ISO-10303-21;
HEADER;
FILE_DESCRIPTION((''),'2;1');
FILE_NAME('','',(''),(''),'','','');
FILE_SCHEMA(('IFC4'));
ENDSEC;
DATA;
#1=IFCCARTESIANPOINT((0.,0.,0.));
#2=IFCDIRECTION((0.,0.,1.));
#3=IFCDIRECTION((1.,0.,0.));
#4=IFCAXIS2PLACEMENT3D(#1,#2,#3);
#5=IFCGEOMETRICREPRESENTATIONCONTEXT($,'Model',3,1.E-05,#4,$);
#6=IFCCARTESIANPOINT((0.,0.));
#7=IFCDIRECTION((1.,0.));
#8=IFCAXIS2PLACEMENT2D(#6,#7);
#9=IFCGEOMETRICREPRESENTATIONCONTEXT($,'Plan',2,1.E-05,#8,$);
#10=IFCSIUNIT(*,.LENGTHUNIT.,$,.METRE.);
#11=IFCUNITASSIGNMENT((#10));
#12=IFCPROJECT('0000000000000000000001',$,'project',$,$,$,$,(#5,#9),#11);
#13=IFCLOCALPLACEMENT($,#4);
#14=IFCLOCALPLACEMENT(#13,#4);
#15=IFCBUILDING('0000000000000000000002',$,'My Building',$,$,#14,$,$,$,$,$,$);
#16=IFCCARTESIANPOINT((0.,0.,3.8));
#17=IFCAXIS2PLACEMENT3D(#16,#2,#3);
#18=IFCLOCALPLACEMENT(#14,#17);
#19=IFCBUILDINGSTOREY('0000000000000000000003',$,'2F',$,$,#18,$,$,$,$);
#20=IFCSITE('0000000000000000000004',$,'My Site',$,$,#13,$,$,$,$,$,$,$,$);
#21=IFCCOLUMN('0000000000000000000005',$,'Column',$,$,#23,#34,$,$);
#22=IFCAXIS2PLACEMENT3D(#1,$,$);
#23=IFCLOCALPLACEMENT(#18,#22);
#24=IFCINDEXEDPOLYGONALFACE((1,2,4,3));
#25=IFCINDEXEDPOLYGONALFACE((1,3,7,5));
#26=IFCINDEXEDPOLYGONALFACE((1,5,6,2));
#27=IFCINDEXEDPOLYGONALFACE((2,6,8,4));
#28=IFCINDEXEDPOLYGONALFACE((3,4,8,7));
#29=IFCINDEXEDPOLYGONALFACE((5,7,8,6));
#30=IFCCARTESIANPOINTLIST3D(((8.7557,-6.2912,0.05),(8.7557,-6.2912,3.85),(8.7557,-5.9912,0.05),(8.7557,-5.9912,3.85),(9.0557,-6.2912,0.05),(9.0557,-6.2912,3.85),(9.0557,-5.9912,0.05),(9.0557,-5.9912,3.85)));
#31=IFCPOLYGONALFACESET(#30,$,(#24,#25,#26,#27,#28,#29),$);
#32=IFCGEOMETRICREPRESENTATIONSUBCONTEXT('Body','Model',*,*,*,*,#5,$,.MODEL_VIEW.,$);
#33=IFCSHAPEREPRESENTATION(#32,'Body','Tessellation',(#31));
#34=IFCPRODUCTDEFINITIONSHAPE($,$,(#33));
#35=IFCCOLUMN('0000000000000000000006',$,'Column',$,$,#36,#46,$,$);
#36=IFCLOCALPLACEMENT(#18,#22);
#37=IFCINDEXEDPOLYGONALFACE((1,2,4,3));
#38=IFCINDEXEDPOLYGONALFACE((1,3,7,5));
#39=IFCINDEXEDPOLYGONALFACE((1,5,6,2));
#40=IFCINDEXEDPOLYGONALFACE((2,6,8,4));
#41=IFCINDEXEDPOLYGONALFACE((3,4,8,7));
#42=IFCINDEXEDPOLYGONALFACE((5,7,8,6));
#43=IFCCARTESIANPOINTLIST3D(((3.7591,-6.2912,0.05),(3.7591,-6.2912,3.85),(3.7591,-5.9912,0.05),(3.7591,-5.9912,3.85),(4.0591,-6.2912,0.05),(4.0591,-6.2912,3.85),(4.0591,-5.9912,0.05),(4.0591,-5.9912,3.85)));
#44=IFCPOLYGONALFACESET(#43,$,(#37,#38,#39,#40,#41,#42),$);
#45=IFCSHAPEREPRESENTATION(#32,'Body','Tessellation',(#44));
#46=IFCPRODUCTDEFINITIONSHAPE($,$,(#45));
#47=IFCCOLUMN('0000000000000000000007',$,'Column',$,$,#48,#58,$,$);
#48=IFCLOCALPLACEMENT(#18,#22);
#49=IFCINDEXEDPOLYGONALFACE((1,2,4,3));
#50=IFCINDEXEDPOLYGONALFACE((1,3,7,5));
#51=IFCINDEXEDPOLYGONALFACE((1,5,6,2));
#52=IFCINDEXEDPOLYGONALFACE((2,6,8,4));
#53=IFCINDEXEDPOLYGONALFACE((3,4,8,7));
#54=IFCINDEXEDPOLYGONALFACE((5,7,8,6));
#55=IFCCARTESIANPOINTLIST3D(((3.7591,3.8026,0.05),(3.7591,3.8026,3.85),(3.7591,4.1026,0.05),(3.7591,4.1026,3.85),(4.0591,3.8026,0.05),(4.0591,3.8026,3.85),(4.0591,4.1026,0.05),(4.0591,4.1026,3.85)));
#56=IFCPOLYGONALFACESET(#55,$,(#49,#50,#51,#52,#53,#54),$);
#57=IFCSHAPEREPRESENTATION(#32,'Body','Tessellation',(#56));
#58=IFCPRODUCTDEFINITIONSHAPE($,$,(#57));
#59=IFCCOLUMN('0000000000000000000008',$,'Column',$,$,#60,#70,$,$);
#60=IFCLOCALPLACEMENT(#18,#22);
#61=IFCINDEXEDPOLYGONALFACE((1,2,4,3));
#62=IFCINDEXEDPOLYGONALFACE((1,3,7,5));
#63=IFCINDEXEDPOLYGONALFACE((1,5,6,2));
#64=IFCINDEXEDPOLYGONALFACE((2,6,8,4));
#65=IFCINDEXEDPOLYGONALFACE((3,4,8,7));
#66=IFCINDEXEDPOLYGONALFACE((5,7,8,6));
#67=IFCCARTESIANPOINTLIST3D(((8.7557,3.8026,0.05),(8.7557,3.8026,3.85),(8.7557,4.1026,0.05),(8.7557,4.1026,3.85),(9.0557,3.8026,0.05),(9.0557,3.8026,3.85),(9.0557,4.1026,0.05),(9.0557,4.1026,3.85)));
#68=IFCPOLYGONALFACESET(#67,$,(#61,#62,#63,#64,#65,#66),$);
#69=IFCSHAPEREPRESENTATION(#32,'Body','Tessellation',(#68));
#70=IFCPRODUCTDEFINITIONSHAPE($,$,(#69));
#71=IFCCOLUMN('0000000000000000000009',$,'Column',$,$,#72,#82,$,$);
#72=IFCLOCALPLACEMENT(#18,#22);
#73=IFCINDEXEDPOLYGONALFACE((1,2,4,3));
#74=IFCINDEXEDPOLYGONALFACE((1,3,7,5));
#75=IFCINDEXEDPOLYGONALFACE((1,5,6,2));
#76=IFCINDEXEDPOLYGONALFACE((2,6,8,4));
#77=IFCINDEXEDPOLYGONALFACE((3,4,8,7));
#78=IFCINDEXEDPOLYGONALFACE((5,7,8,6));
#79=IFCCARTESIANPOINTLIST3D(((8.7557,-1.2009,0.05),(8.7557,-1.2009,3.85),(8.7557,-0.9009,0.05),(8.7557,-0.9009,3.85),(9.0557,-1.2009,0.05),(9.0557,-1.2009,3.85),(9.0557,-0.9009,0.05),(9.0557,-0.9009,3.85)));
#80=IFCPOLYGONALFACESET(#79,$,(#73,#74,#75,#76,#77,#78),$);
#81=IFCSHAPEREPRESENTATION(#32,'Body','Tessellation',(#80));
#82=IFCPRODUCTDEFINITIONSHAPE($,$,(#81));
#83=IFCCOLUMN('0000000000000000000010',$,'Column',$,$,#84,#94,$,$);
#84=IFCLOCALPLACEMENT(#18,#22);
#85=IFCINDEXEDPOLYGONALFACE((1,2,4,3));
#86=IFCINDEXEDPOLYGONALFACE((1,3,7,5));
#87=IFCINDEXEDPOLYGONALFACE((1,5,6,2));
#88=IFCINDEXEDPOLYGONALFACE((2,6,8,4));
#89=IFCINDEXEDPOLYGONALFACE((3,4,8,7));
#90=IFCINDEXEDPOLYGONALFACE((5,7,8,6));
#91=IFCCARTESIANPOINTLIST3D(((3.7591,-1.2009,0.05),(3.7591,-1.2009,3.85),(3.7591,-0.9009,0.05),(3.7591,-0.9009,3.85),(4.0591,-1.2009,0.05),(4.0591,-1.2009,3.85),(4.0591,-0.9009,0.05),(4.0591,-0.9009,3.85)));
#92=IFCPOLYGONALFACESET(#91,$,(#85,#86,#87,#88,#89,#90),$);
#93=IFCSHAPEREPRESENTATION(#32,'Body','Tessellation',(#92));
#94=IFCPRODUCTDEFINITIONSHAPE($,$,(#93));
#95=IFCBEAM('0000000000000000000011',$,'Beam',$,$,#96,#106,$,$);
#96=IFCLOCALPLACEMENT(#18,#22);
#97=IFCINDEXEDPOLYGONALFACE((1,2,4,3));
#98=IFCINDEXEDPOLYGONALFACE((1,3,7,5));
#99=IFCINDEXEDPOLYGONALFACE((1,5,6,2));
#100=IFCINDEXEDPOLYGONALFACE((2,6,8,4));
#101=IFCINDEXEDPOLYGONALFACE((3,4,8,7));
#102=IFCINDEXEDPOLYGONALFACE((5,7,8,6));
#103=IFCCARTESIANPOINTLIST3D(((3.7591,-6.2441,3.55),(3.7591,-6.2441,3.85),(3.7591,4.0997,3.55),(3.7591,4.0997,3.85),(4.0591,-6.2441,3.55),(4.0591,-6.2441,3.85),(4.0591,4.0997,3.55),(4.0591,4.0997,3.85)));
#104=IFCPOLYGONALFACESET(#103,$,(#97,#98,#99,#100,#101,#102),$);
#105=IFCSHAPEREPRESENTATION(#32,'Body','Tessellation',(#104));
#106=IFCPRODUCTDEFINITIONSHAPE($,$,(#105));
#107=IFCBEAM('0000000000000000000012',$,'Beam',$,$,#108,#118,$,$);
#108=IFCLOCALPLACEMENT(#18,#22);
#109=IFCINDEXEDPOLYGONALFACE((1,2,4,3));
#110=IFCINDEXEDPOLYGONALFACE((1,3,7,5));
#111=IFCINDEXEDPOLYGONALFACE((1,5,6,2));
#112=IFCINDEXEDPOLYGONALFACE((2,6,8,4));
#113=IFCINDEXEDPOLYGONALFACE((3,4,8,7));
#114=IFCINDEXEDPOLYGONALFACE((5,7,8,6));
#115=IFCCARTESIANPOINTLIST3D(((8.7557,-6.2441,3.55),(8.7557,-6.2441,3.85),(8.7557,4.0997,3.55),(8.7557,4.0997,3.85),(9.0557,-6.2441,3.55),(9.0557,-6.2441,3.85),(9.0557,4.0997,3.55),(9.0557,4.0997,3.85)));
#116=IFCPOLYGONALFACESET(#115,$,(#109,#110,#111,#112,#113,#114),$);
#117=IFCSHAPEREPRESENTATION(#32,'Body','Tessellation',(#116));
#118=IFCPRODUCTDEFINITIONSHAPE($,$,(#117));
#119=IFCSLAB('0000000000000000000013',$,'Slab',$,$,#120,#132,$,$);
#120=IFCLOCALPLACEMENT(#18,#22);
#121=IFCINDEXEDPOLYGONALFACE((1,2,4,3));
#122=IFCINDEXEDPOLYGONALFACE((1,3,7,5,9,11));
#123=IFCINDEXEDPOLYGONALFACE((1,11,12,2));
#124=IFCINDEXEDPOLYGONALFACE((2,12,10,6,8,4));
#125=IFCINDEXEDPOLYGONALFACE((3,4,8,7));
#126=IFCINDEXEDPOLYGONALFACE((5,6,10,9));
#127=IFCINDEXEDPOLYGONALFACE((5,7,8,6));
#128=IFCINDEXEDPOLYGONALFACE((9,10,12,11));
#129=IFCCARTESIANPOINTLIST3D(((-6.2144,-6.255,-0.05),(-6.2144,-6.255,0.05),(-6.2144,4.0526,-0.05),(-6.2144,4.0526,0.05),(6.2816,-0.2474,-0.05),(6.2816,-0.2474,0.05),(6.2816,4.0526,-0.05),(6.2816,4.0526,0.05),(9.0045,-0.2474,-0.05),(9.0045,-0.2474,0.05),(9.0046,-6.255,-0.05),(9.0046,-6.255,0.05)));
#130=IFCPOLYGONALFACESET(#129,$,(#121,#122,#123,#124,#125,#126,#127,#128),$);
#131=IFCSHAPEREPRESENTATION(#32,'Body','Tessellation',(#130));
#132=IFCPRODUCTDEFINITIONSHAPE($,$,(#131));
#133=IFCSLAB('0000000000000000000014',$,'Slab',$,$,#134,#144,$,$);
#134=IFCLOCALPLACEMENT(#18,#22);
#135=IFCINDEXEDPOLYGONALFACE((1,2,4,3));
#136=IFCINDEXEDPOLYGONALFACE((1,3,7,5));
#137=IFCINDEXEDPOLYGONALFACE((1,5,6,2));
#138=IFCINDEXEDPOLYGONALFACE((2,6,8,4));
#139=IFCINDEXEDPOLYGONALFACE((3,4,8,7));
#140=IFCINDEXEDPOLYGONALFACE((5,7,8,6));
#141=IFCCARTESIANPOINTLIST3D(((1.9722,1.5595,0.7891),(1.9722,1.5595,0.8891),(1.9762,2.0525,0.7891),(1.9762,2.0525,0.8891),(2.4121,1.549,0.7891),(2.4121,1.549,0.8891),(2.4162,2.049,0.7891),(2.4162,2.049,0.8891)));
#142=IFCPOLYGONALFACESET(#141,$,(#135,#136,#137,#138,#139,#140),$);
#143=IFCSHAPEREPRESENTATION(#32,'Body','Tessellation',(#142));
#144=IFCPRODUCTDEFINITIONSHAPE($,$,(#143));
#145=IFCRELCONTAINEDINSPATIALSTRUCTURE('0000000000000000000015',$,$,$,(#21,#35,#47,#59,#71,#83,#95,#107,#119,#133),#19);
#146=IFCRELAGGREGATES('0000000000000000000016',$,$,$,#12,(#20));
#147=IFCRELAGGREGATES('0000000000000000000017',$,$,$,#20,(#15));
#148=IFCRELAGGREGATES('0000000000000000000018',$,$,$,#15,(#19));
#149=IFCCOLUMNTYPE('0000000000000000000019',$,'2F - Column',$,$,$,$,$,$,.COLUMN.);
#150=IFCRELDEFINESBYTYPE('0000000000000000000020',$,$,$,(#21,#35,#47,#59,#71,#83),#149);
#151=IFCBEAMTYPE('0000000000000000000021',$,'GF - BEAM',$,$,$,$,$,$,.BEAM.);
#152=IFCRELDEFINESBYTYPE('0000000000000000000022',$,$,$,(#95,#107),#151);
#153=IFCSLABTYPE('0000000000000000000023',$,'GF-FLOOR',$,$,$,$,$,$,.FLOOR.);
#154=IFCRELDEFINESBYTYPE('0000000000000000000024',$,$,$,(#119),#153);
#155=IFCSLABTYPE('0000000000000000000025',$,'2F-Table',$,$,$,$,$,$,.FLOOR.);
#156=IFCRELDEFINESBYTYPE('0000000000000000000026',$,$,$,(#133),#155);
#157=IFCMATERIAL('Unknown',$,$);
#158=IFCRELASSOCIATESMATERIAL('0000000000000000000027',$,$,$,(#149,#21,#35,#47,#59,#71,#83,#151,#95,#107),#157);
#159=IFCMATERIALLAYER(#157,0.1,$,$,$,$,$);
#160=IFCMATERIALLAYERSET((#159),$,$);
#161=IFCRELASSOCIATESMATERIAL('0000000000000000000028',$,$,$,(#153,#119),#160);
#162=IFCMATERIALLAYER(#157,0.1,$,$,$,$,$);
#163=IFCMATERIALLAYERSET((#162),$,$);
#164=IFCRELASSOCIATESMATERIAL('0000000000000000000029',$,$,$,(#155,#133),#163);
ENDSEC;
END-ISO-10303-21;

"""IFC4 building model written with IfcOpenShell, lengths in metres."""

from ifc_helpers import new_model, si_unit, frame, origin_with_axes, origin_2d_with_axis, place, context, subcontext, project, spatial, indexed_curve, rectangle, outline, extrude, material, layer, layer_set, layer_usage, material_profile, profile_set, profile_usage, type_object, element, save


model = new_model("IFC4")

# Units and contexts
model_context = context("Model", 3, precision=1e-05, world=origin_with_axes())
plan_context = context("Plan", 2, precision=1e-05, world=origin_2d_with_axis())
body_context_1 = subcontext(model_context, "Body", "Model", "MODEL_VIEW")
ifc_project = project(units=[si_unit("LENGTHUNIT", "METRE")], contexts=[model_context, plan_context])

# Site, building, storey
site_placement = place(None, origin_with_axes())
site = spatial("IfcSite", under=ifc_project, at=site_placement, Name="My Site")
building_placement = place(site_placement, origin_with_axes())
building = spatial("IfcBuilding", under=site, at=building_placement, Name="My Building")
storey_placement = place(building_placement, frame((0.0, 0.0, 3.8), z_axis=(0.0, 0.0, 1.0), x_axis=(1.0, 0.0, 0.0)))
storey = spatial("IfcBuildingStorey", under=building, at=storey_placement, Name="2F")

# Columns
ifc_material = material(Name="Unknown")
ifc_material_profile_1 = material_profile(ifc_material, rectangle(XDim=0.3, YDim=0.3))
ifc_profile_set_1 = profile_set([ifc_material_profile_1])
ifc_profile_usage_1 = profile_usage(ifc_profile_set_1, cardinal=5)
column_type = type_object("IfcColumnType", Name="2F - Column", PredefinedType="COLUMN", material=ifc_profile_set_1)
column_1_placement = place(storey_placement, frame((8.9057, -6.1412, 0.05), z_axis=(0.0, 0.0, 1.0), x_axis=(1.0, 0.0, 0.0)))
element("IfcColumn", 1, at=column_1_placement, inside=storey, type_object=column_type, material=ifc_profile_usage_1, Name="Column", context=body_context_1, shape_type="SweptSolid", body=[
    extrude(rectangle(XDim=0.3, YDim=0.3), origin_with_axes(), (0.0, 0.0, 1.0), 3.8),
])
ifc_profile_usage_2 = profile_usage(ifc_profile_set_1, cardinal=5)
column_2_placement = place(storey_placement, frame((3.9091, -6.1412, 0.05), z_axis=(0.0, 0.0, 1.0), x_axis=(1.0, 0.0, 0.0)))
element("IfcColumn", 2, at=column_2_placement, inside=storey, type_object=column_type, material=ifc_profile_usage_2, Name="Column", context=body_context_1, shape_type="SweptSolid", body=[
    extrude(rectangle(XDim=0.3, YDim=0.3), origin_with_axes(), (0.0, 0.0, 1.0), 3.8),
])
ifc_profile_usage_3 = profile_usage(ifc_profile_set_1, cardinal=5)
column_3_placement = place(storey_placement, frame((3.9091, 3.9526, 0.05), z_axis=(0.0, 0.0, 1.0), x_axis=(1.0, 0.0, 0.0)))
element("IfcColumn", 3, at=column_3_placement, inside=storey, type_object=column_type, material=ifc_profile_usage_3, Name="Column", context=body_context_1, shape_type="SweptSolid", body=[
    extrude(rectangle(XDim=0.3, YDim=0.3), origin_with_axes(), (0.0, 0.0, 1.0), 3.8),
])
ifc_profile_usage_4 = profile_usage(ifc_profile_set_1, cardinal=5)
column_4_placement = place(storey_placement, frame((8.9057, 3.9526, 0.05), z_axis=(0.0, 0.0, 1.0), x_axis=(1.0, 0.0, 0.0)))
element("IfcColumn", 4, at=column_4_placement, inside=storey, type_object=column_type, material=ifc_profile_usage_4, Name="Column", context=body_context_1, shape_type="SweptSolid", body=[
    extrude(rectangle(XDim=0.3, YDim=0.3), origin_with_axes(), (0.0, 0.0, 1.0), 3.8),
])
ifc_profile_usage_5 = profile_usage(ifc_profile_set_1, cardinal=5)
column_5_placement = place(storey_placement, frame((8.9057, -1.0509, 0.05), z_axis=(0.0, 0.0, 1.0), x_axis=(1.0, 0.0, 0.0)))
element("IfcColumn", 5, at=column_5_placement, inside=storey, type_object=column_type, material=ifc_profile_usage_5, Name="Column", context=body_context_1, shape_type="SweptSolid", body=[
    extrude(rectangle(XDim=0.3, YDim=0.3), origin_with_axes(), (0.0, 0.0, 1.0), 3.8),
])
ifc_profile_usage_6 = profile_usage(ifc_profile_set_1, cardinal=5)
column_6_placement = place(storey_placement, frame((3.9091, -1.0509, 0.05), z_axis=(0.0, 0.0, 1.0), x_axis=(1.0, 0.0, 0.0)))
element("IfcColumn", 6, at=column_6_placement, inside=storey, type_object=column_type, material=ifc_profile_usage_6, Name="Column", context=body_context_1, shape_type="SweptSolid", body=[
    extrude(rectangle(XDim=0.3, YDim=0.3), origin_with_axes(), (0.0, 0.0, 1.0), 3.8),
])

# Beams
ifc_material_profile_2 = material_profile(ifc_material, rectangle(XDim=0.3, YDim=0.3))
ifc_profile_set_2 = profile_set([ifc_material_profile_2])
ifc_profile_usage_7 = profile_usage(ifc_profile_set_2, cardinal=5)
beam_type = type_object("IfcBeamType", Name="GF - BEAM", PredefinedType="BEAM", material=ifc_profile_set_2)
beam_1_placement = place(storey_placement, frame((3.9091, -6.2441, 3.7), z_axis=(0.0, 1.0, 0.0), x_axis=(-1.0, 0.0, 0.0)))
element("IfcBeam", 7, at=beam_1_placement, inside=storey, type_object=beam_type, material=ifc_profile_usage_7, Name="Beam", context=body_context_1, shape_type="SweptSolid", body=[
    extrude(rectangle(XDim=0.3, YDim=0.3), origin_with_axes(), (0.0, 0.0, 1.0), 10.3438),
])
ifc_profile_usage_8 = profile_usage(ifc_profile_set_2, cardinal=5)
beam_2_placement = place(storey_placement, frame((8.9057, -6.2441, 3.7), z_axis=(0.0, 1.0, 0.0), x_axis=(-1.0, 0.0, 0.0)))
element("IfcBeam", 8, at=beam_2_placement, inside=storey, type_object=beam_type, material=ifc_profile_usage_8, Name="Beam", context=body_context_1, shape_type="SweptSolid", body=[
    extrude(rectangle(XDim=0.3, YDim=0.3), origin_with_axes(), (0.0, 0.0, 1.0), 10.3438),
])

# Slabs
ifc_layer_1 = layer(ifc_material, 0.1)
ifc_layer_set_1 = layer_set([ifc_layer_1])
ifc_layer_usage_1 = layer_usage(ifc_layer_set_1, "AXIS3", "POSITIVE", -0.1)
slab_type_1 = type_object("IfcSlabType", Name="GF-FLOOR", PredefinedType="FLOOR", material=ifc_layer_set_1)
slab_1_placement = place(storey_placement, frame((9.0046, -6.255, 0.05), z_axis=(0.0, 0.0, 1.0), x_axis=(1.0, 0.0, 0.0)))
element("IfcSlab", 9, at=slab_1_placement, inside=storey, type_object=slab_type_1, material=ifc_layer_usage_1, Name="Slab", context=body_context_1, shape_type="SweptSolid", body=[
    extrude(outline(indexed_curve([(0.0, 0.0), (-15.219, 0.0), (-15.219, 10.3076), (-2.7231, 10.3076), (-2.7231, 6.0077), (-0.0001, 6.0077), (0.0, 0.0)])), frame((0.0, 0.0, -0.1), z_axis=(0.0, 0.0, 1.0), x_axis=(1.0, 0.0, 0.0)), (0.0, 0.0, 1.0), 0.1),
])
ifc_layer_2 = layer(ifc_material, 0.1)
ifc_layer_set_2 = layer_set([ifc_layer_2])
ifc_layer_usage_2 = layer_usage(ifc_layer_set_2, "AXIS3", "POSITIVE", -0.1)
slab_type_2 = type_object("IfcSlabType", Name="2F-Table", PredefinedType="FLOOR", material=ifc_layer_set_2)
slab_2_placement = place(storey_placement, frame((1.9722, 1.5595, 0.8891), z_axis=(0.0, 0.0, 1.0), x_axis=(1.0, 0.0, 0.0)))
element("IfcSlab", 10, at=slab_2_placement, inside=storey, type_object=slab_type_2, material=ifc_layer_usage_2, Name="Slab", context=body_context_1, shape_type="SweptSolid", body=[
    extrude(outline(indexed_curve([(0.0, 0.0), (0.004, 0.493), (0.444, 0.4894), (0.4399, -0.0105), (0.0, 0.0)])), frame((0.0, 0.0, -0.1), z_axis=(0.0, 0.0, 1.0), x_axis=(1.0, 0.0, 0.0)), (0.0, 0.0, 1.0), 0.1),
])

save(model, "model.ifc")
